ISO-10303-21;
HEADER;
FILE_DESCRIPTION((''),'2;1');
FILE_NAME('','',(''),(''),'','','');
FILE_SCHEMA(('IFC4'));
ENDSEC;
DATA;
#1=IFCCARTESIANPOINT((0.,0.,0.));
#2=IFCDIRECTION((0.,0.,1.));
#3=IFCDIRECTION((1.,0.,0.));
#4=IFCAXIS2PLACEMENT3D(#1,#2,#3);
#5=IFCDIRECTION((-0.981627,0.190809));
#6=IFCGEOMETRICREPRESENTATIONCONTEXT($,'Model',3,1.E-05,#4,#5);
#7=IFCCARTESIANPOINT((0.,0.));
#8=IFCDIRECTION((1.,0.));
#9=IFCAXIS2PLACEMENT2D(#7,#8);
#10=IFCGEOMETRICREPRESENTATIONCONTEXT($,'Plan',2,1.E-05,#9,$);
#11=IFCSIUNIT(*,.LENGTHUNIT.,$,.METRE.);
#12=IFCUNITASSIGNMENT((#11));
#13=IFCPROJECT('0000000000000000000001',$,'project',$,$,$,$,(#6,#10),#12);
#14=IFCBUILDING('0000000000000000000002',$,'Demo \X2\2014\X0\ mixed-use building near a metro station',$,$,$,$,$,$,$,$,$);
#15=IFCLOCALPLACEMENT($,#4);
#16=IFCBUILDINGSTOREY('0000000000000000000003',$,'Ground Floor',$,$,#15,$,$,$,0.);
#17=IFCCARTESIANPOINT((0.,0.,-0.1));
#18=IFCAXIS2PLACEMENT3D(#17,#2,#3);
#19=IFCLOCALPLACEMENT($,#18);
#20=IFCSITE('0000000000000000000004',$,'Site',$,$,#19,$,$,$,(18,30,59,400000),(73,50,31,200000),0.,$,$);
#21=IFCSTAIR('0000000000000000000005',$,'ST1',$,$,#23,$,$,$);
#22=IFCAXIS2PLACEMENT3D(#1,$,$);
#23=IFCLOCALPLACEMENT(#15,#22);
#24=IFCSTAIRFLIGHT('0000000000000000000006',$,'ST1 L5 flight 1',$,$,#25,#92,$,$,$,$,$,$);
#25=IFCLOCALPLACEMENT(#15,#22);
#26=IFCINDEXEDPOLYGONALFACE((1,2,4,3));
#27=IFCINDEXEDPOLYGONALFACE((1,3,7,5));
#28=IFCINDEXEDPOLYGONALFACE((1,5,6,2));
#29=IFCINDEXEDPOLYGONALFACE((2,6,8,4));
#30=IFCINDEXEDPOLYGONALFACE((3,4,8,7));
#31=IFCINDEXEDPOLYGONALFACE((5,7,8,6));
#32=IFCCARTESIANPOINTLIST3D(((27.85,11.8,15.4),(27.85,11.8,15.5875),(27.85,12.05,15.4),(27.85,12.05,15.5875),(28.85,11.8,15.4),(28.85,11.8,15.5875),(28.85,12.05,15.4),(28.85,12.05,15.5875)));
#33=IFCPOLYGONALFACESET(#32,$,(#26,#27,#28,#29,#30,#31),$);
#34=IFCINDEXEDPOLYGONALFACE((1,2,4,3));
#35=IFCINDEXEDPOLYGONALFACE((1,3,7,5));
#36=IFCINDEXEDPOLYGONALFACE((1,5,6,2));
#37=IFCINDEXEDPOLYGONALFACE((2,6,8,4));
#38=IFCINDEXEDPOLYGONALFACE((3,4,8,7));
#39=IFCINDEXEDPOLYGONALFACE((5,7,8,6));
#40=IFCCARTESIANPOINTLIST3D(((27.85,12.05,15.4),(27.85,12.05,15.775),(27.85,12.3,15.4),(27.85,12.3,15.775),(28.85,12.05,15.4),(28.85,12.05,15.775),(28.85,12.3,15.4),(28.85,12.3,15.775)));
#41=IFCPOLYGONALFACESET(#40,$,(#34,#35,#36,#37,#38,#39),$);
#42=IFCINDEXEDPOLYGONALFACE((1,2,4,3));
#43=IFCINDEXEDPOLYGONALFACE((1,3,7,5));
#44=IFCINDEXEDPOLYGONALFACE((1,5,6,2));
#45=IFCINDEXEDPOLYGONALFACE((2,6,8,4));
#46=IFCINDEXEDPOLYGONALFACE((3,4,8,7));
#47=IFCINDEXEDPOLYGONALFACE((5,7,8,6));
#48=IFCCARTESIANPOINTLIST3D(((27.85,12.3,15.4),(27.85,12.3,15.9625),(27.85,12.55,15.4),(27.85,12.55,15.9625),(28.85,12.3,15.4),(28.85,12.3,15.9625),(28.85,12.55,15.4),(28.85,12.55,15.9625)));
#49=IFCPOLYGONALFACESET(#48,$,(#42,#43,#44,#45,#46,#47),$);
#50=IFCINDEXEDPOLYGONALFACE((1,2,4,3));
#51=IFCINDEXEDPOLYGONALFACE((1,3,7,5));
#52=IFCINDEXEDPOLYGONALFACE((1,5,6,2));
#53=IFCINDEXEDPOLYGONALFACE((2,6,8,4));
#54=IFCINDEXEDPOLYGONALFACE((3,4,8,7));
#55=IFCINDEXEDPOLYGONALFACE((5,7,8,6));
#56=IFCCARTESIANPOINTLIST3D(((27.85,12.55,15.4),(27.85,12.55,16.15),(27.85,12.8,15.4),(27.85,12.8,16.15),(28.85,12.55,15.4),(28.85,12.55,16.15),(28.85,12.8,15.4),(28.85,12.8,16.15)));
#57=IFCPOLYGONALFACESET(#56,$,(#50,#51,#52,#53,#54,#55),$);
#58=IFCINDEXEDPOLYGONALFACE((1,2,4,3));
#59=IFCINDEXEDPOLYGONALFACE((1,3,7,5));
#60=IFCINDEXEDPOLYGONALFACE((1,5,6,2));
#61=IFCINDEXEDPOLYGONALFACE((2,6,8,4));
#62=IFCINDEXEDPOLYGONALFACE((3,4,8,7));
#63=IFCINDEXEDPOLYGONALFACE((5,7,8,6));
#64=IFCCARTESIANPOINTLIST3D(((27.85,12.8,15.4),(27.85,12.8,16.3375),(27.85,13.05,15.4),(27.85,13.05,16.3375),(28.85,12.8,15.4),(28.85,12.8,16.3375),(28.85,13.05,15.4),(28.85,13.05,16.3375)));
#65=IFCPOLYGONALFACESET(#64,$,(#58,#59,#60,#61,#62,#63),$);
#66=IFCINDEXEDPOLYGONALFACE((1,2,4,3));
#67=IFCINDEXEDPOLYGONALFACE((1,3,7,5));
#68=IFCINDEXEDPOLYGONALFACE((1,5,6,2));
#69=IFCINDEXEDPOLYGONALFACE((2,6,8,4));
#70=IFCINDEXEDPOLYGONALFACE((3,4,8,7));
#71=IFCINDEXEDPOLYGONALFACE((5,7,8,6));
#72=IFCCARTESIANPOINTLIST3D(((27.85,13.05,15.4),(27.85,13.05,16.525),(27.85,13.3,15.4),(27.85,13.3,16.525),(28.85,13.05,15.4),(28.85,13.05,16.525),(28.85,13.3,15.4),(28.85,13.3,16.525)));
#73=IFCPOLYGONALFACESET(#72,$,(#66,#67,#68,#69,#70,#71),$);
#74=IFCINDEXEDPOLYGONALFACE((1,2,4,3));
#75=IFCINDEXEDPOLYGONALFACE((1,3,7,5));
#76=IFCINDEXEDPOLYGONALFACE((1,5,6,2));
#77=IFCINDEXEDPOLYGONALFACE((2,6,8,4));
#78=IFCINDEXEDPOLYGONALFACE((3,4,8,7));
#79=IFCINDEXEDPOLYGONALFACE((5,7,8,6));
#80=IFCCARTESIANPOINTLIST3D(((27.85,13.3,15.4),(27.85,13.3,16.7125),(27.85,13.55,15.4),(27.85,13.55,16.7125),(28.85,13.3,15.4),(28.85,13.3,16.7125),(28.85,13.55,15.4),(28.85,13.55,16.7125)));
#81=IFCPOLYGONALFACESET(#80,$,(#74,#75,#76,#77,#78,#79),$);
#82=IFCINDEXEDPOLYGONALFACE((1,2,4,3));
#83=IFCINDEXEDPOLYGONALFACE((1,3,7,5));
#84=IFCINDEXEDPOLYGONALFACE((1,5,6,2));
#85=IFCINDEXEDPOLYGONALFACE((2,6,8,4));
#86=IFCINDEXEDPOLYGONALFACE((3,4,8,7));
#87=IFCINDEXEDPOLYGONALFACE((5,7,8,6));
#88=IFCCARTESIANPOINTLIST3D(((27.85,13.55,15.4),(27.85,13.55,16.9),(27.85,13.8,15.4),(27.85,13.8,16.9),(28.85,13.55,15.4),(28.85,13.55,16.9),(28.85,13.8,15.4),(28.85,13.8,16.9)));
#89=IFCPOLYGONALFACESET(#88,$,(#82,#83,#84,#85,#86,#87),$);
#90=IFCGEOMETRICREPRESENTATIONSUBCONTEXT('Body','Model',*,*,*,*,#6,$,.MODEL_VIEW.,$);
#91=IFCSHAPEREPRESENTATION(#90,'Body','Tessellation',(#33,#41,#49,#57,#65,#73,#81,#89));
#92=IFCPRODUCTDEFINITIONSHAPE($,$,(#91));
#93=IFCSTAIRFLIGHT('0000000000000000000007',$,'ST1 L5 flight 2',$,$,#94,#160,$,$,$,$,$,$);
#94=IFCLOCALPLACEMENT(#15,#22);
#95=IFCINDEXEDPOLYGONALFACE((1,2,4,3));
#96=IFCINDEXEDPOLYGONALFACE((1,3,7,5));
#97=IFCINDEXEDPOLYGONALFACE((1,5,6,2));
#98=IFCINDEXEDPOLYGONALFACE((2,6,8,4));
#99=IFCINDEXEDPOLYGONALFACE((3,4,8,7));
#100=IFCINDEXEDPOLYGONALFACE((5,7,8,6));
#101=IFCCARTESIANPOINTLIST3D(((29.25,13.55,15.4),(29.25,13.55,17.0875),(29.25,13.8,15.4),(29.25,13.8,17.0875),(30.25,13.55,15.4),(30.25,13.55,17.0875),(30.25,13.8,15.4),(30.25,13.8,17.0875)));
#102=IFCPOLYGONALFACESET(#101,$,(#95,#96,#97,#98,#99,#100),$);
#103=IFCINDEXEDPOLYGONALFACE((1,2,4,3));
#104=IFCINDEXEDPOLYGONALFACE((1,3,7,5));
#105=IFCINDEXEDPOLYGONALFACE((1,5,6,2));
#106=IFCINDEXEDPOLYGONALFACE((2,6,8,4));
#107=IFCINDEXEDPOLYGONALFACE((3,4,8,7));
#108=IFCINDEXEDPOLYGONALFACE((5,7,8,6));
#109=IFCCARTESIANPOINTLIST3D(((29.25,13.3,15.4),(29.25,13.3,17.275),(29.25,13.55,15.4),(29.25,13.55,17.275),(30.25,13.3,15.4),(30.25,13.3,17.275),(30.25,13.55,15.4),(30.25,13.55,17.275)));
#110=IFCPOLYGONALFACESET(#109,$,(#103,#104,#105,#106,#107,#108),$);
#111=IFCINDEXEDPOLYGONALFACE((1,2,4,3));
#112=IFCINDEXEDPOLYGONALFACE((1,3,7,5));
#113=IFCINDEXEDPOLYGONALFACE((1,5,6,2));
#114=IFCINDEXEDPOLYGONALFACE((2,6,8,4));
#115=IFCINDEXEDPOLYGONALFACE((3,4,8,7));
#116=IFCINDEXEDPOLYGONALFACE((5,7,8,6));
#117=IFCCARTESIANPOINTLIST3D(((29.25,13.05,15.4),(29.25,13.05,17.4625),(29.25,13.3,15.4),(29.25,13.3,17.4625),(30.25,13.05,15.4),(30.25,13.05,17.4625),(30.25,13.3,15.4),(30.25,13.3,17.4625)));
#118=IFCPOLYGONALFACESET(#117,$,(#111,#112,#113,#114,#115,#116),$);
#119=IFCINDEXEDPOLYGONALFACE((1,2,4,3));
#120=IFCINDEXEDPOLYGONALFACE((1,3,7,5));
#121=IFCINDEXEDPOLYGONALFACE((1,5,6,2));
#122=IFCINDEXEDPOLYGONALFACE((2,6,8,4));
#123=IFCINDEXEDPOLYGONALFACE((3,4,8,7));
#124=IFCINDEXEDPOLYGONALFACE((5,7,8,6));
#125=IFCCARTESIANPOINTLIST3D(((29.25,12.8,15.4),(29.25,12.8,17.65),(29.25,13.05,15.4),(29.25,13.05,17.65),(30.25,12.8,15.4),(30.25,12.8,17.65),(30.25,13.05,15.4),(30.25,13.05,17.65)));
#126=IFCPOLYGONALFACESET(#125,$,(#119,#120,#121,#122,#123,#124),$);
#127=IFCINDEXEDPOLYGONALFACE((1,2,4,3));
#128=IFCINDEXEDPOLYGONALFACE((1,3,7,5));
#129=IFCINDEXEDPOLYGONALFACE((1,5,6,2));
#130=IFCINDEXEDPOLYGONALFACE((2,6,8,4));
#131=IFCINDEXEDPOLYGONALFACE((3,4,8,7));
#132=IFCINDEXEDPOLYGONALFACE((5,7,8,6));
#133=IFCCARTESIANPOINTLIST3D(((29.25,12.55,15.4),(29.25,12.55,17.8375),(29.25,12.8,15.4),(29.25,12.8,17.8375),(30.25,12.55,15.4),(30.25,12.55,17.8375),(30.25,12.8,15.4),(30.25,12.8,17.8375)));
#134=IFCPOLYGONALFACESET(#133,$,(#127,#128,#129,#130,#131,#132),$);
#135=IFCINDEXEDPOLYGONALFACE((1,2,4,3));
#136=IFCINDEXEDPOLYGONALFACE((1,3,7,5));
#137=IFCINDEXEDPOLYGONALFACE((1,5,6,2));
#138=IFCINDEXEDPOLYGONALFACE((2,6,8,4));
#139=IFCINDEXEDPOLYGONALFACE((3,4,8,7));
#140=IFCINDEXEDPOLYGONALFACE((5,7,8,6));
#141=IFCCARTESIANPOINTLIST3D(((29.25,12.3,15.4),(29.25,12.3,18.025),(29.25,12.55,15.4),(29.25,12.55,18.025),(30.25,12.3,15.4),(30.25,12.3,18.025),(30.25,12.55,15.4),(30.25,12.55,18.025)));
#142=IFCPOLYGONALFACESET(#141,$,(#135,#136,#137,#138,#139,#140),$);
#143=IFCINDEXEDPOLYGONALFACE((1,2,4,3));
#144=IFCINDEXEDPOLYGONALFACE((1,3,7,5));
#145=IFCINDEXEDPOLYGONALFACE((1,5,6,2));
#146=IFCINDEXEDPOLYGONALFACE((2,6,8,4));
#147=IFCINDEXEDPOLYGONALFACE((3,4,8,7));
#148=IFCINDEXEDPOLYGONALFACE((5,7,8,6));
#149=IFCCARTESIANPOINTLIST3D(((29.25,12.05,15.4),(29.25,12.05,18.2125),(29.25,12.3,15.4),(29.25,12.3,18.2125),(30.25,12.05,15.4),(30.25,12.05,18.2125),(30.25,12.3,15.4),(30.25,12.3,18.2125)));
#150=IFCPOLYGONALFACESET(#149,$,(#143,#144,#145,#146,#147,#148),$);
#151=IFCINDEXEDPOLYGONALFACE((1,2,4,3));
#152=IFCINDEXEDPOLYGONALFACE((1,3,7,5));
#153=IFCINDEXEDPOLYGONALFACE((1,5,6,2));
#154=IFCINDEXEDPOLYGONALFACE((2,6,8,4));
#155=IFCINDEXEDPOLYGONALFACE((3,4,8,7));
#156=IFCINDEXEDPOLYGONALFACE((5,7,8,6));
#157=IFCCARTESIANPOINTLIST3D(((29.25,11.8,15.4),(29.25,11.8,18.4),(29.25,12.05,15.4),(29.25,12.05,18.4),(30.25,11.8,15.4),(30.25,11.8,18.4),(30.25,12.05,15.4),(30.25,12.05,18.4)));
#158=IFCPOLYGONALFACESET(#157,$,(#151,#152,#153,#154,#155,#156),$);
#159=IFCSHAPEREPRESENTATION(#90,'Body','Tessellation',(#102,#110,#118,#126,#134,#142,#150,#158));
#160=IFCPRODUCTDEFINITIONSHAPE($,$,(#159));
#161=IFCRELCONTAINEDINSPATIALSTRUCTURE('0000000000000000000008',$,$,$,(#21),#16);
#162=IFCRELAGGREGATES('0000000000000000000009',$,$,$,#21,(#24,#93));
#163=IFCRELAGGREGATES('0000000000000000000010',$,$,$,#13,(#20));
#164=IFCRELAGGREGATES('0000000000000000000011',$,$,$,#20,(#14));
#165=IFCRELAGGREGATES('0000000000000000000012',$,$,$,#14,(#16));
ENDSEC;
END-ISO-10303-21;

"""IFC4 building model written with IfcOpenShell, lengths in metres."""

from ifc_helpers import new_model, si_unit, direction, frame, origin_with_axes, origin_2d_with_axis, place, context, subcontext, project, spatial, line, indexed_curve, outline, extrude, element, aggregate, save


model = new_model("IFC4")

# Units and contexts
model_context = context("Model", 3, precision=1e-05, world=origin_with_axes(), true_north=direction((-0.981627, 0.190809)))
plan_context = context("Plan", 2, precision=1e-05, world=origin_2d_with_axis())
body_context = subcontext(model_context, "Body", "Model", "MODEL_VIEW")
ifc_project = project(units=[si_unit("LENGTHUNIT", "METRE")], contexts=[model_context, plan_context])

# Site, building, storey
site_placement = place(None, frame((0.0, 0.0, -0.1), z_axis=(0.0, 0.0, 1.0), x_axis=(1.0, 0.0, 0.0)))
site = spatial("IfcSite", under=ifc_project, at=site_placement, Name="Site", RefLatitude=(18, 30, 59, 400000), RefLongitude=(73, 50, 31, 200000), RefElevation=0.0)
building = spatial("IfcBuilding", under=site, Name="Demo — mixed-use building near a metro station")
storey_placement = place(None, origin_with_axes())
storey = spatial("IfcBuildingStorey", under=building, at=storey_placement, Name="Ground Floor", Elevation=0.0)

# Stair, stair flights
stair = element("IfcStair", 1, inside=storey, Name="ST1")
stair_flight_1_placement = place(None, origin_with_axes())
stair_flight_1 = element("IfcStairFlight", 2, at=stair_flight_1_placement, Name="ST1 L5 flight 1", context=body_context, shape_type="SweptSolid", body=[
    extrude(outline(indexed_curve([(27.85, 11.8), (28.85, 11.8), (28.85, 12.05), (27.85, 12.05)], segments=[line(1, 2, 3, 4, 1)])), frame((0.0, 0.0, 15.4), z_axis=(0.0, 0.0, 1.0), x_axis=(1.0, 0.0, 0.0)), (0.0, 0.0, 1.0), 0.1875),
    extrude(outline(indexed_curve([(27.85, 12.05), (28.85, 12.05), (28.85, 12.3), (27.85, 12.3)], segments=[line(1, 2, 3, 4, 1)])), frame((0.0, 0.0, 15.4), z_axis=(0.0, 0.0, 1.0), x_axis=(1.0, 0.0, 0.0)), (0.0, 0.0, 1.0), 0.375),
    extrude(outline(indexed_curve([(27.85, 12.3), (28.85, 12.3), (28.85, 12.55), (27.85, 12.55)], segments=[line(1, 2, 3, 4, 1)])), frame((0.0, 0.0, 15.4), z_axis=(0.0, 0.0, 1.0), x_axis=(1.0, 0.0, 0.0)), (0.0, 0.0, 1.0), 0.5625),
    extrude(outline(indexed_curve([(27.85, 12.55), (28.85, 12.55), (28.85, 12.8), (27.85, 12.8)], segments=[line(1, 2, 3, 4, 1)])), frame((0.0, 0.0, 15.4), z_axis=(0.0, 0.0, 1.0), x_axis=(1.0, 0.0, 0.0)), (0.0, 0.0, 1.0), 0.75),
    extrude(outline(indexed_curve([(27.85, 12.8), (28.85, 12.8), (28.85, 13.05), (27.85, 13.05)], segments=[line(1, 2, 3, 4, 1)])), frame((0.0, 0.0, 15.4), z_axis=(0.0, 0.0, 1.0), x_axis=(1.0, 0.0, 0.0)), (0.0, 0.0, 1.0), 0.9375),
    extrude(outline(indexed_curve([(27.85, 13.05), (28.85, 13.05), (28.85, 13.3), (27.85, 13.3)], segments=[line(1, 2, 3, 4, 1)])), frame((0.0, 0.0, 15.4), z_axis=(0.0, 0.0, 1.0), x_axis=(1.0, 0.0, 0.0)), (0.0, 0.0, 1.0), 1.125),
    extrude(outline(indexed_curve([(27.85, 13.3), (28.85, 13.3), (28.85, 13.55), (27.85, 13.55)], segments=[line(1, 2, 3, 4, 1)])), frame((0.0, 0.0, 15.4), z_axis=(0.0, 0.0, 1.0), x_axis=(1.0, 0.0, 0.0)), (0.0, 0.0, 1.0), 1.3125),
    extrude(outline(indexed_curve([(27.85, 13.55), (28.85, 13.55), (28.85, 13.8), (27.85, 13.8)], segments=[line(1, 2, 3, 4, 1)])), frame((0.0, 0.0, 15.4), z_axis=(0.0, 0.0, 1.0), x_axis=(1.0, 0.0, 0.0)), (0.0, 0.0, 1.0), 1.5),
])
stair_flight_2_placement = place(None, origin_with_axes())
stair_flight_2 = element("IfcStairFlight", 3, at=stair_flight_2_placement, Name="ST1 L5 flight 2", context=body_context, shape_type="SweptSolid", body=[
    extrude(outline(indexed_curve([(29.25, 13.55), (30.25, 13.55), (30.25, 13.8), (29.25, 13.8)], segments=[line(1, 2, 3, 4, 1)])), frame((0.0, 0.0, 15.4), z_axis=(0.0, 0.0, 1.0), x_axis=(1.0, 0.0, 0.0)), (0.0, 0.0, 1.0), 1.6875),
    extrude(outline(indexed_curve([(29.25, 13.3), (30.25, 13.3), (30.25, 13.55), (29.25, 13.55)], segments=[line(1, 2, 3, 4, 1)])), frame((0.0, 0.0, 15.4), z_axis=(0.0, 0.0, 1.0), x_axis=(1.0, 0.0, 0.0)), (0.0, 0.0, 1.0), 1.875),
    extrude(outline(indexed_curve([(29.25, 13.05), (30.25, 13.05), (30.25, 13.3), (29.25, 13.3)], segments=[line(1, 2, 3, 4, 1)])), frame((0.0, 0.0, 15.4), z_axis=(0.0, 0.0, 1.0), x_axis=(1.0, 0.0, 0.0)), (0.0, 0.0, 1.0), 2.0625),
    extrude(outline(indexed_curve([(29.25, 12.8), (30.25, 12.8), (30.25, 13.05), (29.25, 13.05)], segments=[line(1, 2, 3, 4, 1)])), frame((0.0, 0.0, 15.4), z_axis=(0.0, 0.0, 1.0), x_axis=(1.0, 0.0, 0.0)), (0.0, 0.0, 1.0), 2.25),
    extrude(outline(indexed_curve([(29.25, 12.55), (30.25, 12.55), (30.25, 12.8), (29.25, 12.8)], segments=[line(1, 2, 3, 4, 1)])), frame((0.0, 0.0, 15.4), z_axis=(0.0, 0.0, 1.0), x_axis=(1.0, 0.0, 0.0)), (0.0, 0.0, 1.0), 2.4375),
    extrude(outline(indexed_curve([(29.25, 12.3), (30.25, 12.3), (30.25, 12.55), (29.25, 12.55)], segments=[line(1, 2, 3, 4, 1)])), frame((0.0, 0.0, 15.4), z_axis=(0.0, 0.0, 1.0), x_axis=(1.0, 0.0, 0.0)), (0.0, 0.0, 1.0), 2.625),
    extrude(outline(indexed_curve([(29.25, 12.05), (30.25, 12.05), (30.25, 12.3), (29.25, 12.3)], segments=[line(1, 2, 3, 4, 1)])), frame((0.0, 0.0, 15.4), z_axis=(0.0, 0.0, 1.0), x_axis=(1.0, 0.0, 0.0)), (0.0, 0.0, 1.0), 2.8125),
    extrude(outline(indexed_curve([(29.25, 11.8), (30.25, 11.8), (30.25, 12.05), (29.25, 12.05)], segments=[line(1, 2, 3, 4, 1)])), frame((0.0, 0.0, 15.4), z_axis=(0.0, 0.0, 1.0), x_axis=(1.0, 0.0, 0.0)), (0.0, 0.0, 1.0), 3.0),
])
aggregate(stair, [stair_flight_1, stair_flight_2])

save(model, "model.ifc")
